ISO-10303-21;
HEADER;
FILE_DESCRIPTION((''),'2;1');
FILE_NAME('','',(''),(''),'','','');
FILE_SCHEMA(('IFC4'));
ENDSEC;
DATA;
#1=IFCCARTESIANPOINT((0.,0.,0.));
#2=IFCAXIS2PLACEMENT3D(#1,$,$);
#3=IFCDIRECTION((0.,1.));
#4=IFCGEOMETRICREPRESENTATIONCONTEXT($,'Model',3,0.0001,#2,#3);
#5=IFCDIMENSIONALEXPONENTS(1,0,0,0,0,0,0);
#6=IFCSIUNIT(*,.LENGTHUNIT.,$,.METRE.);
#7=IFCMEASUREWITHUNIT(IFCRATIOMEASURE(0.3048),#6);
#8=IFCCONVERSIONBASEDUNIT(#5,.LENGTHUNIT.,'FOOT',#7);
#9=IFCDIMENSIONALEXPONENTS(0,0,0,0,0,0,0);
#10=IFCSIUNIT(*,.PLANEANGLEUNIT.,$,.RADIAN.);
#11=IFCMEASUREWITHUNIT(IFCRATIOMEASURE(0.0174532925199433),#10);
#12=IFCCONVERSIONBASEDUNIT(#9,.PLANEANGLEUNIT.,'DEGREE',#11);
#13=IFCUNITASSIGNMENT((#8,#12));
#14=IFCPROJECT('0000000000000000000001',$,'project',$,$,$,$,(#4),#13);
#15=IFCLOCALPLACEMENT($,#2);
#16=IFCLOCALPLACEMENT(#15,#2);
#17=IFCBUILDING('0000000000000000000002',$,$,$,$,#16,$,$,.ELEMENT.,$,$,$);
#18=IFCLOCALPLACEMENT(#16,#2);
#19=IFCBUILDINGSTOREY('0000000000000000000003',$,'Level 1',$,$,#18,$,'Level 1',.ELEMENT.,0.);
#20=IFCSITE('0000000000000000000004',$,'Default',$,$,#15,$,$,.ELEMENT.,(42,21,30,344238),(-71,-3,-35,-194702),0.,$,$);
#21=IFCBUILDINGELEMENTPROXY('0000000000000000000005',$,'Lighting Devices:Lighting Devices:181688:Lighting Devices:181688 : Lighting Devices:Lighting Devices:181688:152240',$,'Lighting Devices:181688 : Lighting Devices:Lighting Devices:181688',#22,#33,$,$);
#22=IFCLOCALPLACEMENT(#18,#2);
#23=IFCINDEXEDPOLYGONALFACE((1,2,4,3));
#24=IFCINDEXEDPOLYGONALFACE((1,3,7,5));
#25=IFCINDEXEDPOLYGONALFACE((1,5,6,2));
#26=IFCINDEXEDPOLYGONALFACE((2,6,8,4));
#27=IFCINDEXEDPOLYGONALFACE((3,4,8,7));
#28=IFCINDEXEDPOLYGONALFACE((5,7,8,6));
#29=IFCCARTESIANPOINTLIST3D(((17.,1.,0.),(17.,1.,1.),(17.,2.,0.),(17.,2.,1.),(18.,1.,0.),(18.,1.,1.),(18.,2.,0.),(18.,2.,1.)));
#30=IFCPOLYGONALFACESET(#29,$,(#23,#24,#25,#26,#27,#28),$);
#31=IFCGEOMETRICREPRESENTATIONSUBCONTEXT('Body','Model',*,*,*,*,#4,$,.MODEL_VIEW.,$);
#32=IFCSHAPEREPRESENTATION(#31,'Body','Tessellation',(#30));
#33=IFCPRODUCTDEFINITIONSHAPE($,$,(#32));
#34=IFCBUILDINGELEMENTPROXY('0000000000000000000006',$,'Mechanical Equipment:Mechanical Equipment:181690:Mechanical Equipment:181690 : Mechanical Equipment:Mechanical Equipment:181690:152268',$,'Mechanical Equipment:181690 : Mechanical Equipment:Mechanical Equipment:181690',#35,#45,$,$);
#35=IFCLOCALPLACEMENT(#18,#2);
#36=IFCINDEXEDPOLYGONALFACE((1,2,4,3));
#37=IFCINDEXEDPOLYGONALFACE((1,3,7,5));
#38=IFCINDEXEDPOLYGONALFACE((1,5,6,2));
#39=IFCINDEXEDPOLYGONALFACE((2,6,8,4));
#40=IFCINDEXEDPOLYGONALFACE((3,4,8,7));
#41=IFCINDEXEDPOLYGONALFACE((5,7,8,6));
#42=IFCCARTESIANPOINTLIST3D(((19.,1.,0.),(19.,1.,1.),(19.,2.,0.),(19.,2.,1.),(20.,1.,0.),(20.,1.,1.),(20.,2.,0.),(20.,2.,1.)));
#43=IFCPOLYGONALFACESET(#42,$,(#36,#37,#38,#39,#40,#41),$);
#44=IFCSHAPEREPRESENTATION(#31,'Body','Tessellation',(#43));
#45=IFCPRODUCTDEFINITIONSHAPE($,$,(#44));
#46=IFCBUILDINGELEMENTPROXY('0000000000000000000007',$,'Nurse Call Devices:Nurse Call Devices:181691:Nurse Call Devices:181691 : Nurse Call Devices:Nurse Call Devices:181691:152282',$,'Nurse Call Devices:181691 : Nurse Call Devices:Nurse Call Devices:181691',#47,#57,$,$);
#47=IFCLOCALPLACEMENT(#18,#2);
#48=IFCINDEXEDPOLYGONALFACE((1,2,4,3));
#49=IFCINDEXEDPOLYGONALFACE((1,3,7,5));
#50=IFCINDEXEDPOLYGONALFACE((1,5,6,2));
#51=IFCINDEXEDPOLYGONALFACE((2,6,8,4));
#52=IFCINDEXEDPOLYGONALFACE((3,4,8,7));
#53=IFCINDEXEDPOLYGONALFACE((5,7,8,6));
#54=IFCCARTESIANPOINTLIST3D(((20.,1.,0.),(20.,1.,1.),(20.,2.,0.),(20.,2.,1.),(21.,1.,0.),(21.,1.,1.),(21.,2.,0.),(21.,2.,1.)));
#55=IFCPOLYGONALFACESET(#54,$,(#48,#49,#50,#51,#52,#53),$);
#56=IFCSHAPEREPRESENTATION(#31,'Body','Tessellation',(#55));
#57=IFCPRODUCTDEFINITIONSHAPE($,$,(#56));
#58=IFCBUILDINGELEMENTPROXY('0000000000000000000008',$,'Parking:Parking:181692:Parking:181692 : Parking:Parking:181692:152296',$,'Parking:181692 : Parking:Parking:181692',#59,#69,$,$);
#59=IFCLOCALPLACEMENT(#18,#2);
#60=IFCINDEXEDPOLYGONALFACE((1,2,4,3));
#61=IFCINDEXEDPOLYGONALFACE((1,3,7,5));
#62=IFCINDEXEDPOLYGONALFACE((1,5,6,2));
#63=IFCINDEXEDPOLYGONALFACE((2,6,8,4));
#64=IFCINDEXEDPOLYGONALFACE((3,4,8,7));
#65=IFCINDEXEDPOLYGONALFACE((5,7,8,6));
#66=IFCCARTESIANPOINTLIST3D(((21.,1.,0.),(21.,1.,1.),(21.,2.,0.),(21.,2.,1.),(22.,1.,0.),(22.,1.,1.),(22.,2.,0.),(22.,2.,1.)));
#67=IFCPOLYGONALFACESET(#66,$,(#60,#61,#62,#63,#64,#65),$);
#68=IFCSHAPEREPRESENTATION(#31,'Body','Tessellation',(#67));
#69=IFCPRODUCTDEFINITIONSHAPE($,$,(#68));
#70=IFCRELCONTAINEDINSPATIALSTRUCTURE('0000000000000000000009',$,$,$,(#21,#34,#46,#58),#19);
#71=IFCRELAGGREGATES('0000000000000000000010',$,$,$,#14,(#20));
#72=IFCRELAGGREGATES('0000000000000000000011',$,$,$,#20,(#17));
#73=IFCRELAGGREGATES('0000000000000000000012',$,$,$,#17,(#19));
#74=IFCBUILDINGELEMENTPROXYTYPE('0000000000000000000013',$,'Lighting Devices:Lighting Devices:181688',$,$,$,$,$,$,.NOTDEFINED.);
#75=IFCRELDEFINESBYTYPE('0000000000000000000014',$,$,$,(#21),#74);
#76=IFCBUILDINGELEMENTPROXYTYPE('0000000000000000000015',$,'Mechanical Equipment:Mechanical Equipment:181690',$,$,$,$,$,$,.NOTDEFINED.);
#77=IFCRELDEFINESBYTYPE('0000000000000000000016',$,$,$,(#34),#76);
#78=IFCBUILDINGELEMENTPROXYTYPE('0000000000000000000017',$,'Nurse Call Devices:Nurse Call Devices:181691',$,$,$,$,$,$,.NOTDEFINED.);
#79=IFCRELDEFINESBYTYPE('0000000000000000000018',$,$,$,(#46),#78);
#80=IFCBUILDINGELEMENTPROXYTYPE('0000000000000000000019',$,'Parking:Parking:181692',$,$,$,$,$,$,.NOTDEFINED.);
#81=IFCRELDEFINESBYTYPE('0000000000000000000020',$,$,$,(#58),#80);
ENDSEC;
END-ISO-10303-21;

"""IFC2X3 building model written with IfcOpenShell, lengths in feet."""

from ifc_helpers import new_model, entity, si_unit, converted_unit, direction, frame, frame_2d, origin, place, context, subcontext, project, spatial, rectangle, extrude, source, transform, mapped, type_object, type_shapes, element, save


model = new_model("IFC2X3")

# Units and contexts
model_context = context("Model", 3, precision=0.0001, world=origin(), true_north=direction((0.0, 1.0)))
body_context = subcontext(model_context, "Body", "Model", "MODEL_VIEW")
ifc_project = project(units=[converted_unit("LENGTHUNIT", "FOOT", entity("IfcRatioMeasure", 0.3048), si_unit("LENGTHUNIT", "METRE"), dimensions=[1, 0, 0, 0, 0, 0, 0]), converted_unit("PLANEANGLEUNIT", "DEGREE", entity("IfcRatioMeasure", 0.0174532925199433), si_unit("PLANEANGLEUNIT", "RADIAN"), dimensions=[0, 0, 0, 0, 0, 0, 0])], contexts=[model_context])

# Site, building, storey
site_placement = place(None, origin())
site = spatial("IfcSite", under=ifc_project, at=site_placement, Name="Default", CompositionType="ELEMENT", RefLatitude=(42, 21, 30, 344238), RefLongitude=(-71, -3, -35, -194702), RefElevation=0.0)
building_placement = place(site_placement, origin())
building = spatial("IfcBuilding", under=site, at=building_placement, CompositionType="ELEMENT")
storey_placement = place(building_placement, origin())
storey = spatial("IfcBuildingStorey", under=building, at=storey_placement, Name="Level 1", LongName="Level 1", CompositionType="ELEMENT", Elevation=0.0)

# Building element proxies
building_element_proxy_type_1 = type_object("IfcBuildingElementProxyType", Name="Lighting Devices:Lighting Devices:181688", PredefinedType="NOTDEFINED")
shared_shape_1 = source(origin(), body_context, "Body", "SweptSolid", [
    extrude(rectangle(XDim=1.0, YDim=1.0, at=frame_2d((0.0, 0.0), x_axis=(1.0, 0.0))), frame((17.5, 1.5, 0.0), z_axis=(0.0, 0.0, 1.0), x_axis=(-1.0, 0.0, 0.0)), (0.0, 0.0, 1.0), 1.0),
])
type_shapes(building_element_proxy_type_1, [shared_shape_1])
proxy_1_placement = place(storey_placement, origin())
element("IfcBuildingElementProxy", 1, at=proxy_1_placement, inside=storey, type_object=building_element_proxy_type_1, Name="Lighting Devices:Lighting Devices:181688:Lighting Devices:181688 : Lighting Devices:Lighting Devices:181688:152240", ObjectType="Lighting Devices:181688 : Lighting Devices:Lighting Devices:181688", context=body_context, shape_type="MappedRepresentation", body=[
    mapped(shared_shape_1, transform((0.0, 0.0, 0.0), scale=1.0)),
])
building_element_proxy_type_2 = type_object("IfcBuildingElementProxyType", Name="Mechanical Equipment:Mechanical Equipment:181690", PredefinedType="NOTDEFINED")
shared_shape_2 = source(origin(), body_context, "Body", "SweptSolid", [
    extrude(rectangle(XDim=1.0, YDim=1.0, at=frame_2d((0.0, 0.0), x_axis=(1.0, 0.0))), frame((19.5, 1.5, 0.0), z_axis=(0.0, 0.0, 1.0), x_axis=(-1.0, 0.0, 0.0)), (0.0, 0.0, 1.0), 1.0),
])
type_shapes(building_element_proxy_type_2, [shared_shape_2])
proxy_2_placement = place(storey_placement, origin())
element("IfcBuildingElementProxy", 2, at=proxy_2_placement, inside=storey, type_object=building_element_proxy_type_2, Name="Mechanical Equipment:Mechanical Equipment:181690:Mechanical Equipment:181690 : Mechanical Equipment:Mechanical Equipment:181690:152268", ObjectType="Mechanical Equipment:181690 : Mechanical Equipment:Mechanical Equipment:181690", context=body_context, shape_type="MappedRepresentation", body=[
    mapped(shared_shape_2, transform((0.0, 0.0, 0.0), scale=1.0)),
])
building_element_proxy_type_3 = type_object("IfcBuildingElementProxyType", Name="Nurse Call Devices:Nurse Call Devices:181691", PredefinedType="NOTDEFINED")
shared_shape_3 = source(origin(), body_context, "Body", "SweptSolid", [
    extrude(rectangle(XDim=1.0, YDim=1.0, at=frame_2d((0.0, 0.0), x_axis=(1.0, 0.0))), frame((20.5, 1.5, 0.0), z_axis=(0.0, 0.0, 1.0), x_axis=(-1.0, 0.0, 0.0)), (0.0, 0.0, 1.0), 1.0),
])
type_shapes(building_element_proxy_type_3, [shared_shape_3])
proxy_3_placement = place(storey_placement, origin())
element("IfcBuildingElementProxy", 3, at=proxy_3_placement, inside=storey, type_object=building_element_proxy_type_3, Name="Nurse Call Devices:Nurse Call Devices:181691:Nurse Call Devices:181691 : Nurse Call Devices:Nurse Call Devices:181691:152282", ObjectType="Nurse Call Devices:181691 : Nurse Call Devices:Nurse Call Devices:181691", context=body_context, shape_type="MappedRepresentation", body=[
    mapped(shared_shape_3, transform((0.0, 0.0, 0.0), scale=1.0)),
])
building_element_proxy_type_4 = type_object("IfcBuildingElementProxyType", Name="Parking:Parking:181692", PredefinedType="NOTDEFINED")
shared_shape_4 = source(origin(), body_context, "Body", "SweptSolid", [
    extrude(rectangle(XDim=1.0, YDim=1.0, at=frame_2d((0.0, 0.0), x_axis=(1.0, 0.0))), frame((21.5, 1.5, 0.0), z_axis=(0.0, 0.0, 1.0), x_axis=(-1.0, 0.0, 0.0)), (0.0, 0.0, 1.0), 1.0),
])
type_shapes(building_element_proxy_type_4, [shared_shape_4])
proxy_4_placement = place(storey_placement, origin())
element("IfcBuildingElementProxy", 4, at=proxy_4_placement, inside=storey, type_object=building_element_proxy_type_4, Name="Parking:Parking:181692:Parking:181692 : Parking:Parking:181692:152296", ObjectType="Parking:181692 : Parking:Parking:181692", context=body_context, shape_type="MappedRepresentation", body=[
    mapped(shared_shape_4, transform((0.0, 0.0, 0.0), scale=1.0)),
])

save(model, "model.ifc")
